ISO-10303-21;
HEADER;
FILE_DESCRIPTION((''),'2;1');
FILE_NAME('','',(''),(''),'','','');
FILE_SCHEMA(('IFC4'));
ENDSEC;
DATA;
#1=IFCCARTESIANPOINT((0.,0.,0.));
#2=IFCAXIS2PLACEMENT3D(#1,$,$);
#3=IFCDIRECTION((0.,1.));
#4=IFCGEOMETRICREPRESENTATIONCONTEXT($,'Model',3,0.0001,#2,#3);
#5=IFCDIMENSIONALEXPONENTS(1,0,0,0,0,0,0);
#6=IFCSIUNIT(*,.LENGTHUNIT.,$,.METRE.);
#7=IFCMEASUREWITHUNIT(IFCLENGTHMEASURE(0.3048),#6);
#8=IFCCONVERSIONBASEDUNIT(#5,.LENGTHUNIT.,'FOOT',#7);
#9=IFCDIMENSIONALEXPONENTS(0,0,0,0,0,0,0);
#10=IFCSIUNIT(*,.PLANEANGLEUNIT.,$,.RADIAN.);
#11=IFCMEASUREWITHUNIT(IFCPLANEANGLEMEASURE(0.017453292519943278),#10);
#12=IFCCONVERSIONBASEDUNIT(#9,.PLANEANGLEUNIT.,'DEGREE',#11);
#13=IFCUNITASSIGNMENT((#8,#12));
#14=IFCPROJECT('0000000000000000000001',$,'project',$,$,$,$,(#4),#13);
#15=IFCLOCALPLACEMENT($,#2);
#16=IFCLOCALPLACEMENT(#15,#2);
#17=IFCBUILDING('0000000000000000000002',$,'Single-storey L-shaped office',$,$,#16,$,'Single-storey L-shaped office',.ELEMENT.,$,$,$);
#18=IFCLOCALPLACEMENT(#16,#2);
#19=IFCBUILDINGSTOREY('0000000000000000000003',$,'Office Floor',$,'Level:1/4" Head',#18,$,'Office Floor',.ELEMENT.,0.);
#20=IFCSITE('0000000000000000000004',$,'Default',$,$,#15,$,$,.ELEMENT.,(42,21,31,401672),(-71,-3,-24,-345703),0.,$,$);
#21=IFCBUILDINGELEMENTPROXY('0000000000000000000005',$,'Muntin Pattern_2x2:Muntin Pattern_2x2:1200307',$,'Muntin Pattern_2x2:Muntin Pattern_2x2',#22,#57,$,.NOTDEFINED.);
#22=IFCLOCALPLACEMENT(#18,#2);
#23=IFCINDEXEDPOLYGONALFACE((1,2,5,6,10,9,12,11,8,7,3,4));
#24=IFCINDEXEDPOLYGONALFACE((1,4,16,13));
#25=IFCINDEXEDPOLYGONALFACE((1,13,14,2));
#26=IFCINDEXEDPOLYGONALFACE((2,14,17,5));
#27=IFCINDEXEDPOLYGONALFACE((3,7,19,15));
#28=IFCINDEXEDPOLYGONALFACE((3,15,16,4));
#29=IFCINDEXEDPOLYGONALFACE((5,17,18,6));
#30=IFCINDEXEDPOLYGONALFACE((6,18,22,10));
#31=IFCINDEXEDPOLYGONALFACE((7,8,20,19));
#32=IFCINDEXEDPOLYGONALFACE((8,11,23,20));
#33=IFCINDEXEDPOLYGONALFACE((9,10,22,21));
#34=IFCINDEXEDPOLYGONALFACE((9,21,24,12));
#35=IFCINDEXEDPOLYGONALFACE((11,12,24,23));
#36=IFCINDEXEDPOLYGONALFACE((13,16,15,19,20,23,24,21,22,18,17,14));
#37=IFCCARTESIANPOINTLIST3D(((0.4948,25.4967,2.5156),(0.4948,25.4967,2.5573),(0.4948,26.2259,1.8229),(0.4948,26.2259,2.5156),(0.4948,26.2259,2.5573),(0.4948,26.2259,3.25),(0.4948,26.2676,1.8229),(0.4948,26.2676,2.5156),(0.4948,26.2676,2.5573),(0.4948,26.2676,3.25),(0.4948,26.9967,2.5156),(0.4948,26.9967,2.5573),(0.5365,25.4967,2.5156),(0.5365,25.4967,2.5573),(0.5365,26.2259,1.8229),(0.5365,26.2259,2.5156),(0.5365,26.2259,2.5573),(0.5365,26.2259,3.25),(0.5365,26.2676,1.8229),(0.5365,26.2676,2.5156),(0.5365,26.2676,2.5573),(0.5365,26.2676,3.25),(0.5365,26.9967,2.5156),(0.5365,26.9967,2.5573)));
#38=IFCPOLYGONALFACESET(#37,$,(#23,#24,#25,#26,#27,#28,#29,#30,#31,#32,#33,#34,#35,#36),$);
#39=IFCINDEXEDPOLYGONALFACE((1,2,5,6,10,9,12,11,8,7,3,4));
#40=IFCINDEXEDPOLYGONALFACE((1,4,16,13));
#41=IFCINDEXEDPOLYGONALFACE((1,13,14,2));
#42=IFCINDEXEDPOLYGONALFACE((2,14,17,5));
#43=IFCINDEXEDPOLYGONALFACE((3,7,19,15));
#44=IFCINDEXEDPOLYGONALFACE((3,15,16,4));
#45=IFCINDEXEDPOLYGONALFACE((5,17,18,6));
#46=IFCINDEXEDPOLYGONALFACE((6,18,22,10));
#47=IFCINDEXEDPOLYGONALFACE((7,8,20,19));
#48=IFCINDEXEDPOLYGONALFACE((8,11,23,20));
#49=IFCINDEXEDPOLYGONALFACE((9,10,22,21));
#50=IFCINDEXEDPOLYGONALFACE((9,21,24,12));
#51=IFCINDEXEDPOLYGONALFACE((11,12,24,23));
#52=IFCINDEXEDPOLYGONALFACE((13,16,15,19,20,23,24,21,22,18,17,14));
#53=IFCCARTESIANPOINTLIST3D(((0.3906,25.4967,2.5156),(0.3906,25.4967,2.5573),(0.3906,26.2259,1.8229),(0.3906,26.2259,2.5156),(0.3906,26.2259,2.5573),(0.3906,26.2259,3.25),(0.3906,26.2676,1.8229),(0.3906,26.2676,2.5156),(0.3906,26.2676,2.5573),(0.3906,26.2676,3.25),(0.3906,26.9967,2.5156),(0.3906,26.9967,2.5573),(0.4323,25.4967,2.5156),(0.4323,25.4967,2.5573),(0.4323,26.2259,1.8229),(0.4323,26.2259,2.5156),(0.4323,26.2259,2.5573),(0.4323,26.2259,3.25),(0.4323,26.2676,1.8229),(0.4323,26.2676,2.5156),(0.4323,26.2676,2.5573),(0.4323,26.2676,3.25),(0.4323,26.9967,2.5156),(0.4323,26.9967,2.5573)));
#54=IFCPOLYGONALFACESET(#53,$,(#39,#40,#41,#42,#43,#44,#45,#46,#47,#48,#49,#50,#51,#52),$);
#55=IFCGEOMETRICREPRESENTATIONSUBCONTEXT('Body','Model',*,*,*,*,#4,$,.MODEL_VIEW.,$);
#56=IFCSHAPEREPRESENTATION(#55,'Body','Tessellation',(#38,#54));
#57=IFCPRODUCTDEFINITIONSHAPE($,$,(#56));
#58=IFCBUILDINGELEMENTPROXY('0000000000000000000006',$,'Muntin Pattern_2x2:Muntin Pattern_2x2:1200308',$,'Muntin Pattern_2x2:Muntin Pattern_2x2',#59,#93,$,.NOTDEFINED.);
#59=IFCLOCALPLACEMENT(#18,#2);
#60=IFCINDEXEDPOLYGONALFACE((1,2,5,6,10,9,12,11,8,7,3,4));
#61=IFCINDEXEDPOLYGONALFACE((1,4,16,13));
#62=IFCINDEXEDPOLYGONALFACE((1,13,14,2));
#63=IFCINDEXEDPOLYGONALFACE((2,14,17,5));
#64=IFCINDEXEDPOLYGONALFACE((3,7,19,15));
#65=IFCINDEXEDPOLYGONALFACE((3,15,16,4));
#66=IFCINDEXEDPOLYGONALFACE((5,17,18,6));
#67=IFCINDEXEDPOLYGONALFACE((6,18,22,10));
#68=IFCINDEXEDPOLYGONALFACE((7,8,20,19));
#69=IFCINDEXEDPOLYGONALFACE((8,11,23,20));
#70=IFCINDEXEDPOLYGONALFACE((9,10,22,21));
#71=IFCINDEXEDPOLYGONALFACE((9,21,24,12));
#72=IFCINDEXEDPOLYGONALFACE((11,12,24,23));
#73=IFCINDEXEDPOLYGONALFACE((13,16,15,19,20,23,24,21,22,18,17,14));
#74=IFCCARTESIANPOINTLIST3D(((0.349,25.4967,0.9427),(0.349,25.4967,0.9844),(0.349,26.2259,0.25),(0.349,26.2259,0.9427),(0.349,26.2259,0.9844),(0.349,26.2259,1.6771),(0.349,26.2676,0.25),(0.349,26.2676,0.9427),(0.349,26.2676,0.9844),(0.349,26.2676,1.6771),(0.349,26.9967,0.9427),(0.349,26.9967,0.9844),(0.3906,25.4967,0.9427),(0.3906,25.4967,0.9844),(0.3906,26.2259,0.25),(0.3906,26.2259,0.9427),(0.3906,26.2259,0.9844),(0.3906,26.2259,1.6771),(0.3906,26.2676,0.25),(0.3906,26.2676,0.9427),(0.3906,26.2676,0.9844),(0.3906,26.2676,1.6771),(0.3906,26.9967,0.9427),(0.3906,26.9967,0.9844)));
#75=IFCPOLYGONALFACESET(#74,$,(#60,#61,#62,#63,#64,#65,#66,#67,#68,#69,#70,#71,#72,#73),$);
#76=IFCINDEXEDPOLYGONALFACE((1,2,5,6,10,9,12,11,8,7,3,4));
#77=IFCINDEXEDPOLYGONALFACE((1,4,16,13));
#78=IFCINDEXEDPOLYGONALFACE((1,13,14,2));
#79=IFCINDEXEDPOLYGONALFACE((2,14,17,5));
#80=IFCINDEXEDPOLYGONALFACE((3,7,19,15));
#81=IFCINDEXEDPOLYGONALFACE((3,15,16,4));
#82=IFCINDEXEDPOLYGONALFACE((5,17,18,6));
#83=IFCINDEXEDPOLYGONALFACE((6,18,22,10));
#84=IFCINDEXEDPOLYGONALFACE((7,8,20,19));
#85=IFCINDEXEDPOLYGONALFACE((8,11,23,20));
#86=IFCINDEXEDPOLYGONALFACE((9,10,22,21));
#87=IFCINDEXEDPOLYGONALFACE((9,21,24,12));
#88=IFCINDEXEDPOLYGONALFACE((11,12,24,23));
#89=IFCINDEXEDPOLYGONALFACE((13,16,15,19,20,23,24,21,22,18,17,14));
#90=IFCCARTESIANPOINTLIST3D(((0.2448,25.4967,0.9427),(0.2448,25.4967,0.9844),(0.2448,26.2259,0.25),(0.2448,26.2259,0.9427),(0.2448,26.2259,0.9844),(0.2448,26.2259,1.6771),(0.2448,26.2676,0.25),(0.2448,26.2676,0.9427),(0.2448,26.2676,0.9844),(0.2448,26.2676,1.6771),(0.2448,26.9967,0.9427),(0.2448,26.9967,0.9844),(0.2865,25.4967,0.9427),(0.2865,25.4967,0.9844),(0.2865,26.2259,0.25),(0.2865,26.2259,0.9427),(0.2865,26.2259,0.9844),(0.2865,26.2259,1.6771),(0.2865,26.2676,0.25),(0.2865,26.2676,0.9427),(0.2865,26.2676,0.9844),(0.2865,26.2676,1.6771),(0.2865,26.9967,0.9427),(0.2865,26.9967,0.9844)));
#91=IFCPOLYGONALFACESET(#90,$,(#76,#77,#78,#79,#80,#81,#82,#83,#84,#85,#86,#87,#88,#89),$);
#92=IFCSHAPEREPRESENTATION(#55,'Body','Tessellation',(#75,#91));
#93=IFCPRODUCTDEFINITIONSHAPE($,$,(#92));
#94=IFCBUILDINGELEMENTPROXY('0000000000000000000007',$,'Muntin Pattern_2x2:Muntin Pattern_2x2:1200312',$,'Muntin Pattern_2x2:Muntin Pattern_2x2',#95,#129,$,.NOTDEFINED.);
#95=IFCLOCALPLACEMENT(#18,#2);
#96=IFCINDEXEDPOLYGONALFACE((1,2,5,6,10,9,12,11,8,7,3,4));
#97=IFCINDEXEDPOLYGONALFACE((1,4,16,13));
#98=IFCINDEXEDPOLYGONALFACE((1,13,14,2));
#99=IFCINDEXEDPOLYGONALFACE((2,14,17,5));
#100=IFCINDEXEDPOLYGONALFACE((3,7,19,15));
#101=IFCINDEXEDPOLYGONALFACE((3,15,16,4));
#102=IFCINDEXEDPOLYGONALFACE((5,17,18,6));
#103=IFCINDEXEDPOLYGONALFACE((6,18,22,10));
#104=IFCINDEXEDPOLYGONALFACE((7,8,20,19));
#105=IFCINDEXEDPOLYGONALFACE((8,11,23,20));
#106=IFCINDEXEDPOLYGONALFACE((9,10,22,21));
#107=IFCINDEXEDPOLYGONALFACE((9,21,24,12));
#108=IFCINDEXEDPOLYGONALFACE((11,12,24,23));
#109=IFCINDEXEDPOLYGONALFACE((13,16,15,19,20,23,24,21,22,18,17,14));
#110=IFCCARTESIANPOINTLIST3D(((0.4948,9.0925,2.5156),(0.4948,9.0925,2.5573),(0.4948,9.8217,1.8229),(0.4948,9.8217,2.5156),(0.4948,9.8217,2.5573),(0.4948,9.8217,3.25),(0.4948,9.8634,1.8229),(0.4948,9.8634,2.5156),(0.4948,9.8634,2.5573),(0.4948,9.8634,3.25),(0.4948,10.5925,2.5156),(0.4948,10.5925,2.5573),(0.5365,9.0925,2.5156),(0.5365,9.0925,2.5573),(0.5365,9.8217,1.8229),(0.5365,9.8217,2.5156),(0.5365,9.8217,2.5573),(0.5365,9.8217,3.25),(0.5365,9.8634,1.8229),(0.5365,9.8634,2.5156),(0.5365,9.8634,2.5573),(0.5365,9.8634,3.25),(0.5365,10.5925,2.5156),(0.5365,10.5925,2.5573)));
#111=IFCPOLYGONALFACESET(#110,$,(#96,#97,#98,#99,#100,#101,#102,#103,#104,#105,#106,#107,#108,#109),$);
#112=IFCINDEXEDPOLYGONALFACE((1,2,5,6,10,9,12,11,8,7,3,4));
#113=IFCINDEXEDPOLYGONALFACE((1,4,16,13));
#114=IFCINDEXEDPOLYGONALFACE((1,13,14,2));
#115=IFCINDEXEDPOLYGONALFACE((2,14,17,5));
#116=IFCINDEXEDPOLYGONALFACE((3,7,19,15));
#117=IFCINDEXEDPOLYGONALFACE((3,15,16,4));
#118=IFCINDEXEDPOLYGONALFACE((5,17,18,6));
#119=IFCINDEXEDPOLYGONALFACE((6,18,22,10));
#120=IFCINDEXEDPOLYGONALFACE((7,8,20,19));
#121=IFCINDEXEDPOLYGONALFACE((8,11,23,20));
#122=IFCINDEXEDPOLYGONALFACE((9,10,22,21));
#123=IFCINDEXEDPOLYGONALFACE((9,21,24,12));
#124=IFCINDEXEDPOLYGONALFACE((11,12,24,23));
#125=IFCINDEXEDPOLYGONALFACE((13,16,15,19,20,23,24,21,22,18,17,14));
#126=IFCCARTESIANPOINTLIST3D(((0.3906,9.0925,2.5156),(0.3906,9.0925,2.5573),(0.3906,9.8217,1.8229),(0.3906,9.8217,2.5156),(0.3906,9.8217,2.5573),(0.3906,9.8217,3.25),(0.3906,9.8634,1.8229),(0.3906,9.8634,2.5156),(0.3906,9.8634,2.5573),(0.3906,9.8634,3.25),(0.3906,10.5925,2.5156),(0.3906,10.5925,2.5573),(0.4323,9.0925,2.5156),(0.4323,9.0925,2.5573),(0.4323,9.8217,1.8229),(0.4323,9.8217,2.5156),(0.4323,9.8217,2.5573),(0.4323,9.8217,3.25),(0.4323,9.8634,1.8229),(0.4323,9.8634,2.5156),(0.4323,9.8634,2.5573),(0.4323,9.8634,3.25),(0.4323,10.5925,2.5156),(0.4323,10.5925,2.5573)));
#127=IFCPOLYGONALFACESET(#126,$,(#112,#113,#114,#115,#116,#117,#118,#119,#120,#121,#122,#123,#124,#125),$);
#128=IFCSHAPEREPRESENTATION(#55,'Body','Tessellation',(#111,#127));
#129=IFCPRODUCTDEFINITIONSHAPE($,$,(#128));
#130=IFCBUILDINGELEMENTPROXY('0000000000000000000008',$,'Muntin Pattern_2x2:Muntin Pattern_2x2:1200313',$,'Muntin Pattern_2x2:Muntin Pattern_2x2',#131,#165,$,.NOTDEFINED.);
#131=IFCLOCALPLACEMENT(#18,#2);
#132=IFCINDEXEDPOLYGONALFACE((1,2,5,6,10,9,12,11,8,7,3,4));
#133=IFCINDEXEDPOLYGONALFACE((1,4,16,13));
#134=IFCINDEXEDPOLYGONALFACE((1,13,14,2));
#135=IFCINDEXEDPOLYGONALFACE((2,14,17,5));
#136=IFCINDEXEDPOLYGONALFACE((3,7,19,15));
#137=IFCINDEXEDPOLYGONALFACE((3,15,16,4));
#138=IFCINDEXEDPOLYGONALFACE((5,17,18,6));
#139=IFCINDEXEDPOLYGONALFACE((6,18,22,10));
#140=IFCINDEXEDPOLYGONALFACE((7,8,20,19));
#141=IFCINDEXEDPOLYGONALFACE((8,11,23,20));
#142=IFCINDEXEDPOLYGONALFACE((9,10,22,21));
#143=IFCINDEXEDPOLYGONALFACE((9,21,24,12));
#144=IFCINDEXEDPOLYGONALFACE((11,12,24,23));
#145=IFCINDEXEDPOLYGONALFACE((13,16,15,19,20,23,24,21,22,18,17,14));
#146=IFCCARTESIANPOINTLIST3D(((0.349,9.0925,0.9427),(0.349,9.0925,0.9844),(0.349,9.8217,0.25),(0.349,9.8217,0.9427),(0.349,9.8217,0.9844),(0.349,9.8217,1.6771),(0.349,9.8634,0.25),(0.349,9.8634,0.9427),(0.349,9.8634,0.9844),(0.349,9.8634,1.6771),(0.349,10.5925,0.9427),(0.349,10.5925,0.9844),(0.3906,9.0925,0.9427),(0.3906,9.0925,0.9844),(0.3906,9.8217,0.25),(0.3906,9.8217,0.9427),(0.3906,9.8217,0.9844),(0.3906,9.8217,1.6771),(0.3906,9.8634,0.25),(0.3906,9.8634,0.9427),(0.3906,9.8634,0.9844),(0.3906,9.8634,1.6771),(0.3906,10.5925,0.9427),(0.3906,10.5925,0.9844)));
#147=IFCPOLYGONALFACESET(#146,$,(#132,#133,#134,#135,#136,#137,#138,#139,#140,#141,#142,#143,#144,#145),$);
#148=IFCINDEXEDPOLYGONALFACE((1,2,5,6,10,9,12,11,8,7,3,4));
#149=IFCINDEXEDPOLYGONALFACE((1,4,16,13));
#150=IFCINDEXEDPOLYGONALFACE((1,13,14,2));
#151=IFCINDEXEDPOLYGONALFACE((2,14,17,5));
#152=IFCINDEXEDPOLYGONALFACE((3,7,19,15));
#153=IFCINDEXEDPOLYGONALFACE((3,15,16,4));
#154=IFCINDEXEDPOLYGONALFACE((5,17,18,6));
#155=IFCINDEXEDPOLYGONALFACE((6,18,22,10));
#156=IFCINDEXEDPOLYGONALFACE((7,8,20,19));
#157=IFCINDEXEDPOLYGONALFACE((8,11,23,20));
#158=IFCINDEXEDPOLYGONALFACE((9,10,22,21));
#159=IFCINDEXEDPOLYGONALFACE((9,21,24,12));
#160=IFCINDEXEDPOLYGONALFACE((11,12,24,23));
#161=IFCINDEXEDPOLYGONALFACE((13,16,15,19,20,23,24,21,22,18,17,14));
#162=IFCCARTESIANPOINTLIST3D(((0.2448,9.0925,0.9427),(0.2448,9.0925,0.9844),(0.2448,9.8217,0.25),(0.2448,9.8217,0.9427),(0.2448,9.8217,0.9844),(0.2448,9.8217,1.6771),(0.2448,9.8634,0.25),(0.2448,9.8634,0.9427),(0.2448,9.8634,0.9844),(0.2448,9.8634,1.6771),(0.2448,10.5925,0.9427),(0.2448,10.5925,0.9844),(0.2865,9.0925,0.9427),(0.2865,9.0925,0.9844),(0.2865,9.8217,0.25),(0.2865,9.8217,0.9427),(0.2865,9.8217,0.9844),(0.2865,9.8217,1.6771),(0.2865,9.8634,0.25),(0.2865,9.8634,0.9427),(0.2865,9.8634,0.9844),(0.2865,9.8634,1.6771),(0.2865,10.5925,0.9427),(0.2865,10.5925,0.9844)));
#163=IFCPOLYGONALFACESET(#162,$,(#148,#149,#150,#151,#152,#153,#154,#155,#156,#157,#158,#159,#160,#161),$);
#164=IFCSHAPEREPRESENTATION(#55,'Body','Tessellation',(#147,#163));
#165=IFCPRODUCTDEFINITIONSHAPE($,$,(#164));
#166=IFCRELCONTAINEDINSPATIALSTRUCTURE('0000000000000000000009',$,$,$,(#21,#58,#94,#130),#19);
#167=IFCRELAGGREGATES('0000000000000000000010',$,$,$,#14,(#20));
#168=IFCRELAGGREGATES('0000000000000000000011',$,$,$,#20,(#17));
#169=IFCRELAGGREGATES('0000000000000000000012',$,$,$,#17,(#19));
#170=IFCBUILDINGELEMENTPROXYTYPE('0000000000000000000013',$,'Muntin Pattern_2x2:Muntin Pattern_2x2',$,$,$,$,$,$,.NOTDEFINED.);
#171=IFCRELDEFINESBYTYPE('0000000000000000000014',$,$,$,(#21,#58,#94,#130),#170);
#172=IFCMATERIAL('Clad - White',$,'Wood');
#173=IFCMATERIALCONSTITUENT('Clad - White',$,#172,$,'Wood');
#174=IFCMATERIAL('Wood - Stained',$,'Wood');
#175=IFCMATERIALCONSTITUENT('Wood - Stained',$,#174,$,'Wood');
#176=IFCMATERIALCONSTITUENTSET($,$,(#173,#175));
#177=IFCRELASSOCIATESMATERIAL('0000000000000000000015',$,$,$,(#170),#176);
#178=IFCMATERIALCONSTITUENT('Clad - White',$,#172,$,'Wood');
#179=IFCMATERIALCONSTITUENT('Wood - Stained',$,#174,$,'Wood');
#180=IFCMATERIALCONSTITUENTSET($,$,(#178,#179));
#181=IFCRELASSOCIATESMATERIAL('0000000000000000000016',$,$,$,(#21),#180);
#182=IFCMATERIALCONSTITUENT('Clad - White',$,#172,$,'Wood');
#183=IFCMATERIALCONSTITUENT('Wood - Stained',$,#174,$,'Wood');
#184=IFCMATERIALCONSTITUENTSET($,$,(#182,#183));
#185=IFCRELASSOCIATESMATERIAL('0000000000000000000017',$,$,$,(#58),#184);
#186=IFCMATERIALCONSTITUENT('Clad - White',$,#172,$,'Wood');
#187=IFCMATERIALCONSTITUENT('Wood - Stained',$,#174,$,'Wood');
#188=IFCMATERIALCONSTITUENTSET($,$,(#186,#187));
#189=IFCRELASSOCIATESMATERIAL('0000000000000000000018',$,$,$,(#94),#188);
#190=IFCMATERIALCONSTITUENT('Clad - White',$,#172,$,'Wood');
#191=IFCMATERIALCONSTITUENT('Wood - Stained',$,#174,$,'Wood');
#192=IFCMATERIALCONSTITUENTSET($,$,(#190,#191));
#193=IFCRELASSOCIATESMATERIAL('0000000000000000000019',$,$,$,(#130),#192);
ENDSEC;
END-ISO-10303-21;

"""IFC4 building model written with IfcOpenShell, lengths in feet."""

from ifc_helpers import new_model, entity, si_unit, converted_unit, direction, frame, origin, place, context, subcontext, project, spatial, indexed_curve, outline, extrude, source, transform, mapped, material, constituent, constituent_set, type_object, type_shapes, element, save


model = new_model("IFC4")

# Units and contexts
model_context = context("Model", 3, precision=0.0001, world=origin(), true_north=direction((0.0, 1.0)))
body_context = subcontext(model_context, "Body", "Model", "MODEL_VIEW")
ifc_project = project(units=[converted_unit("LENGTHUNIT", "FOOT", entity("IfcLengthMeasure", 0.3048), si_unit("LENGTHUNIT", "METRE"), dimensions=[1, 0, 0, 0, 0, 0, 0]), converted_unit("PLANEANGLEUNIT", "DEGREE", entity("IfcPlaneAngleMeasure", 0.017453292519943278), si_unit("PLANEANGLEUNIT", "RADIAN"), dimensions=[0, 0, 0, 0, 0, 0, 0])], contexts=[model_context])

# Site, building, storey
site_placement = place(None, origin())
site = spatial("IfcSite", under=ifc_project, at=site_placement, Name="Default", CompositionType="ELEMENT", RefLatitude=(42, 21, 31, 401672), RefLongitude=(-71, -3, -24, -345703), RefElevation=0.0)
building_placement = place(site_placement, origin())
building = spatial("IfcBuilding", under=site, at=building_placement, Name="Single-storey L-shaped office", LongName="Single-storey L-shaped office", CompositionType="ELEMENT")
storey_placement = place(building_placement, origin())
storey = spatial("IfcBuildingStorey", under=building, at=storey_placement, Name="Office Floor", ObjectType="Level:1/4\" Head", LongName="Office Floor", CompositionType="ELEMENT", Elevation=0.0)

# Shared definitions
ifc_material_1 = material(Name="Wood - Stained", Category="Wood")

# Building element proxies
ifc_material_2 = material(Name="Clad - White", Category="Wood")
ifc_constituent_1 = constituent(ifc_material_2, Name="Clad - White", Category="Wood")
ifc_constituent_2 = constituent(ifc_material_1, Name="Wood - Stained", Category="Wood")
ifc_constituent_set_1 = constituent_set(constituents=[ifc_constituent_1, ifc_constituent_2])
building_element_proxy_type_1 = type_object("IfcBuildingElementProxyType", Name="Muntin Pattern_2x2:Muntin Pattern_2x2", PredefinedType="NOTDEFINED", material=ifc_constituent_set_1)
shared_shape_1 = source(origin(), body_context, "Body", "SweptSolid", [
    extrude(outline(indexed_curve([(0.0208, -0.0208), (0.7135, -0.0208), (0.7135, 0.0208), (0.0208, 0.0208), (0.0208, 0.75), (-0.0208, 0.75), (-0.0208, 0.0208), (-0.7135, 0.0208), (-0.7135, -0.0208), (-0.0208, -0.0208), (-0.0208, -0.75), (0.0208, -0.75), (0.0208, -0.0208)], self_intersect=False)), frame((0.0, 0.0312, 0.7135), z_axis=(0.0, 1.0, 0.0), x_axis=(0.0, 0.0, 1.0)), (0.0, 0.0, 1.0), 0.0417),
    extrude(outline(indexed_curve([(0.0208, -0.0208), (0.7135, -0.0208), (0.7135, 0.0208), (0.0208, 0.0208), (0.0208, 0.75), (-0.0208, 0.75), (-0.0208, 0.0208), (-0.7135, 0.0208), (-0.7135, -0.0208), (-0.0208, -0.0208), (-0.0208, -0.75), (0.0208, -0.75), (0.0208, -0.0208)], self_intersect=False)), frame((0.0, -0.0729, 0.7135), z_axis=(0.0, 1.0, 0.0), x_axis=(0.0, 0.0, 1.0)), (0.0, 0.0, 1.0), 0.0417),
])
type_shapes(building_element_proxy_type_1, [shared_shape_1])
ifc_constituent_3 = constituent(ifc_material_2, Name="Clad - White", Category="Wood")
ifc_constituent_4 = constituent(ifc_material_1, Name="Wood - Stained", Category="Wood")
ifc_constituent_set_2 = constituent_set(constituents=[ifc_constituent_3, ifc_constituent_4])
proxy_1_placement = place(storey_placement, frame((0.4635, 26.2467, 1.8229), z_axis=(0.0, 0.0, 1.0), x_axis=(0.0, -1.0, 0.0)))
element("IfcBuildingElementProxy", 1, at=proxy_1_placement, inside=storey, type_object=building_element_proxy_type_1, material=ifc_constituent_set_2, Name="Muntin Pattern_2x2:Muntin Pattern_2x2:1200307", ObjectType="Muntin Pattern_2x2:Muntin Pattern_2x2", PredefinedType="NOTDEFINED", context=body_context, shape_type="MappedRepresentation", body=[
    mapped(shared_shape_1, transform((0.0, 0.0, 0.0), scale=1.0)),
])
ifc_constituent_5 = constituent(ifc_material_2, Name="Clad - White", Category="Wood")
ifc_constituent_6 = constituent(ifc_material_1, Name="Wood - Stained", Category="Wood")
ifc_constituent_set_3 = constituent_set(constituents=[ifc_constituent_5, ifc_constituent_6])
proxy_2_placement = place(storey_placement, frame((0.3177, 26.2467, 0.25), z_axis=(0.0, 0.0, 1.0), x_axis=(0.0, -1.0, 0.0)))
element("IfcBuildingElementProxy", 2, at=proxy_2_placement, inside=storey, type_object=building_element_proxy_type_1, material=ifc_constituent_set_3, Name="Muntin Pattern_2x2:Muntin Pattern_2x2:1200308", ObjectType="Muntin Pattern_2x2:Muntin Pattern_2x2", PredefinedType="NOTDEFINED", context=body_context, shape_type="MappedRepresentation", body=[
    mapped(shared_shape_1, transform((0.0, 0.0, 0.0), scale=1.0)),
])
ifc_constituent_7 = constituent(ifc_material_2, Name="Clad - White", Category="Wood")
ifc_constituent_8 = constituent(ifc_material_1, Name="Wood - Stained", Category="Wood")
ifc_constituent_set_4 = constituent_set(constituents=[ifc_constituent_7, ifc_constituent_8])
proxy_3_placement = place(storey_placement, frame((0.4635, 9.8425, 1.8229), z_axis=(0.0, 0.0, 1.0), x_axis=(0.0, -1.0, 0.0)))
element("IfcBuildingElementProxy", 3, at=proxy_3_placement, inside=storey, type_object=building_element_proxy_type_1, material=ifc_constituent_set_4, Name="Muntin Pattern_2x2:Muntin Pattern_2x2:1200312", ObjectType="Muntin Pattern_2x2:Muntin Pattern_2x2", PredefinedType="NOTDEFINED", context=body_context, shape_type="MappedRepresentation", body=[
    mapped(shared_shape_1, transform((0.0, 0.0, 0.0), scale=1.0)),
])
ifc_constituent_9 = constituent(ifc_material_2, Name="Clad - White", Category="Wood")
ifc_constituent_10 = constituent(ifc_material_1, Name="Wood - Stained", Category="Wood")
ifc_constituent_set_5 = constituent_set(constituents=[ifc_constituent_9, ifc_constituent_10])
proxy_4_placement = place(storey_placement, frame((0.3177, 9.8425, 0.25), z_axis=(0.0, 0.0, 1.0), x_axis=(0.0, -1.0, 0.0)))
element("IfcBuildingElementProxy", 4, at=proxy_4_placement, inside=storey, type_object=building_element_proxy_type_1, material=ifc_constituent_set_5, Name="Muntin Pattern_2x2:Muntin Pattern_2x2:1200313", ObjectType="Muntin Pattern_2x2:Muntin Pattern_2x2", PredefinedType="NOTDEFINED", context=body_context, shape_type="MappedRepresentation", body=[
    mapped(shared_shape_1, transform((0.0, 0.0, 0.0), scale=1.0)),
])

save(model, "model.ifc")
